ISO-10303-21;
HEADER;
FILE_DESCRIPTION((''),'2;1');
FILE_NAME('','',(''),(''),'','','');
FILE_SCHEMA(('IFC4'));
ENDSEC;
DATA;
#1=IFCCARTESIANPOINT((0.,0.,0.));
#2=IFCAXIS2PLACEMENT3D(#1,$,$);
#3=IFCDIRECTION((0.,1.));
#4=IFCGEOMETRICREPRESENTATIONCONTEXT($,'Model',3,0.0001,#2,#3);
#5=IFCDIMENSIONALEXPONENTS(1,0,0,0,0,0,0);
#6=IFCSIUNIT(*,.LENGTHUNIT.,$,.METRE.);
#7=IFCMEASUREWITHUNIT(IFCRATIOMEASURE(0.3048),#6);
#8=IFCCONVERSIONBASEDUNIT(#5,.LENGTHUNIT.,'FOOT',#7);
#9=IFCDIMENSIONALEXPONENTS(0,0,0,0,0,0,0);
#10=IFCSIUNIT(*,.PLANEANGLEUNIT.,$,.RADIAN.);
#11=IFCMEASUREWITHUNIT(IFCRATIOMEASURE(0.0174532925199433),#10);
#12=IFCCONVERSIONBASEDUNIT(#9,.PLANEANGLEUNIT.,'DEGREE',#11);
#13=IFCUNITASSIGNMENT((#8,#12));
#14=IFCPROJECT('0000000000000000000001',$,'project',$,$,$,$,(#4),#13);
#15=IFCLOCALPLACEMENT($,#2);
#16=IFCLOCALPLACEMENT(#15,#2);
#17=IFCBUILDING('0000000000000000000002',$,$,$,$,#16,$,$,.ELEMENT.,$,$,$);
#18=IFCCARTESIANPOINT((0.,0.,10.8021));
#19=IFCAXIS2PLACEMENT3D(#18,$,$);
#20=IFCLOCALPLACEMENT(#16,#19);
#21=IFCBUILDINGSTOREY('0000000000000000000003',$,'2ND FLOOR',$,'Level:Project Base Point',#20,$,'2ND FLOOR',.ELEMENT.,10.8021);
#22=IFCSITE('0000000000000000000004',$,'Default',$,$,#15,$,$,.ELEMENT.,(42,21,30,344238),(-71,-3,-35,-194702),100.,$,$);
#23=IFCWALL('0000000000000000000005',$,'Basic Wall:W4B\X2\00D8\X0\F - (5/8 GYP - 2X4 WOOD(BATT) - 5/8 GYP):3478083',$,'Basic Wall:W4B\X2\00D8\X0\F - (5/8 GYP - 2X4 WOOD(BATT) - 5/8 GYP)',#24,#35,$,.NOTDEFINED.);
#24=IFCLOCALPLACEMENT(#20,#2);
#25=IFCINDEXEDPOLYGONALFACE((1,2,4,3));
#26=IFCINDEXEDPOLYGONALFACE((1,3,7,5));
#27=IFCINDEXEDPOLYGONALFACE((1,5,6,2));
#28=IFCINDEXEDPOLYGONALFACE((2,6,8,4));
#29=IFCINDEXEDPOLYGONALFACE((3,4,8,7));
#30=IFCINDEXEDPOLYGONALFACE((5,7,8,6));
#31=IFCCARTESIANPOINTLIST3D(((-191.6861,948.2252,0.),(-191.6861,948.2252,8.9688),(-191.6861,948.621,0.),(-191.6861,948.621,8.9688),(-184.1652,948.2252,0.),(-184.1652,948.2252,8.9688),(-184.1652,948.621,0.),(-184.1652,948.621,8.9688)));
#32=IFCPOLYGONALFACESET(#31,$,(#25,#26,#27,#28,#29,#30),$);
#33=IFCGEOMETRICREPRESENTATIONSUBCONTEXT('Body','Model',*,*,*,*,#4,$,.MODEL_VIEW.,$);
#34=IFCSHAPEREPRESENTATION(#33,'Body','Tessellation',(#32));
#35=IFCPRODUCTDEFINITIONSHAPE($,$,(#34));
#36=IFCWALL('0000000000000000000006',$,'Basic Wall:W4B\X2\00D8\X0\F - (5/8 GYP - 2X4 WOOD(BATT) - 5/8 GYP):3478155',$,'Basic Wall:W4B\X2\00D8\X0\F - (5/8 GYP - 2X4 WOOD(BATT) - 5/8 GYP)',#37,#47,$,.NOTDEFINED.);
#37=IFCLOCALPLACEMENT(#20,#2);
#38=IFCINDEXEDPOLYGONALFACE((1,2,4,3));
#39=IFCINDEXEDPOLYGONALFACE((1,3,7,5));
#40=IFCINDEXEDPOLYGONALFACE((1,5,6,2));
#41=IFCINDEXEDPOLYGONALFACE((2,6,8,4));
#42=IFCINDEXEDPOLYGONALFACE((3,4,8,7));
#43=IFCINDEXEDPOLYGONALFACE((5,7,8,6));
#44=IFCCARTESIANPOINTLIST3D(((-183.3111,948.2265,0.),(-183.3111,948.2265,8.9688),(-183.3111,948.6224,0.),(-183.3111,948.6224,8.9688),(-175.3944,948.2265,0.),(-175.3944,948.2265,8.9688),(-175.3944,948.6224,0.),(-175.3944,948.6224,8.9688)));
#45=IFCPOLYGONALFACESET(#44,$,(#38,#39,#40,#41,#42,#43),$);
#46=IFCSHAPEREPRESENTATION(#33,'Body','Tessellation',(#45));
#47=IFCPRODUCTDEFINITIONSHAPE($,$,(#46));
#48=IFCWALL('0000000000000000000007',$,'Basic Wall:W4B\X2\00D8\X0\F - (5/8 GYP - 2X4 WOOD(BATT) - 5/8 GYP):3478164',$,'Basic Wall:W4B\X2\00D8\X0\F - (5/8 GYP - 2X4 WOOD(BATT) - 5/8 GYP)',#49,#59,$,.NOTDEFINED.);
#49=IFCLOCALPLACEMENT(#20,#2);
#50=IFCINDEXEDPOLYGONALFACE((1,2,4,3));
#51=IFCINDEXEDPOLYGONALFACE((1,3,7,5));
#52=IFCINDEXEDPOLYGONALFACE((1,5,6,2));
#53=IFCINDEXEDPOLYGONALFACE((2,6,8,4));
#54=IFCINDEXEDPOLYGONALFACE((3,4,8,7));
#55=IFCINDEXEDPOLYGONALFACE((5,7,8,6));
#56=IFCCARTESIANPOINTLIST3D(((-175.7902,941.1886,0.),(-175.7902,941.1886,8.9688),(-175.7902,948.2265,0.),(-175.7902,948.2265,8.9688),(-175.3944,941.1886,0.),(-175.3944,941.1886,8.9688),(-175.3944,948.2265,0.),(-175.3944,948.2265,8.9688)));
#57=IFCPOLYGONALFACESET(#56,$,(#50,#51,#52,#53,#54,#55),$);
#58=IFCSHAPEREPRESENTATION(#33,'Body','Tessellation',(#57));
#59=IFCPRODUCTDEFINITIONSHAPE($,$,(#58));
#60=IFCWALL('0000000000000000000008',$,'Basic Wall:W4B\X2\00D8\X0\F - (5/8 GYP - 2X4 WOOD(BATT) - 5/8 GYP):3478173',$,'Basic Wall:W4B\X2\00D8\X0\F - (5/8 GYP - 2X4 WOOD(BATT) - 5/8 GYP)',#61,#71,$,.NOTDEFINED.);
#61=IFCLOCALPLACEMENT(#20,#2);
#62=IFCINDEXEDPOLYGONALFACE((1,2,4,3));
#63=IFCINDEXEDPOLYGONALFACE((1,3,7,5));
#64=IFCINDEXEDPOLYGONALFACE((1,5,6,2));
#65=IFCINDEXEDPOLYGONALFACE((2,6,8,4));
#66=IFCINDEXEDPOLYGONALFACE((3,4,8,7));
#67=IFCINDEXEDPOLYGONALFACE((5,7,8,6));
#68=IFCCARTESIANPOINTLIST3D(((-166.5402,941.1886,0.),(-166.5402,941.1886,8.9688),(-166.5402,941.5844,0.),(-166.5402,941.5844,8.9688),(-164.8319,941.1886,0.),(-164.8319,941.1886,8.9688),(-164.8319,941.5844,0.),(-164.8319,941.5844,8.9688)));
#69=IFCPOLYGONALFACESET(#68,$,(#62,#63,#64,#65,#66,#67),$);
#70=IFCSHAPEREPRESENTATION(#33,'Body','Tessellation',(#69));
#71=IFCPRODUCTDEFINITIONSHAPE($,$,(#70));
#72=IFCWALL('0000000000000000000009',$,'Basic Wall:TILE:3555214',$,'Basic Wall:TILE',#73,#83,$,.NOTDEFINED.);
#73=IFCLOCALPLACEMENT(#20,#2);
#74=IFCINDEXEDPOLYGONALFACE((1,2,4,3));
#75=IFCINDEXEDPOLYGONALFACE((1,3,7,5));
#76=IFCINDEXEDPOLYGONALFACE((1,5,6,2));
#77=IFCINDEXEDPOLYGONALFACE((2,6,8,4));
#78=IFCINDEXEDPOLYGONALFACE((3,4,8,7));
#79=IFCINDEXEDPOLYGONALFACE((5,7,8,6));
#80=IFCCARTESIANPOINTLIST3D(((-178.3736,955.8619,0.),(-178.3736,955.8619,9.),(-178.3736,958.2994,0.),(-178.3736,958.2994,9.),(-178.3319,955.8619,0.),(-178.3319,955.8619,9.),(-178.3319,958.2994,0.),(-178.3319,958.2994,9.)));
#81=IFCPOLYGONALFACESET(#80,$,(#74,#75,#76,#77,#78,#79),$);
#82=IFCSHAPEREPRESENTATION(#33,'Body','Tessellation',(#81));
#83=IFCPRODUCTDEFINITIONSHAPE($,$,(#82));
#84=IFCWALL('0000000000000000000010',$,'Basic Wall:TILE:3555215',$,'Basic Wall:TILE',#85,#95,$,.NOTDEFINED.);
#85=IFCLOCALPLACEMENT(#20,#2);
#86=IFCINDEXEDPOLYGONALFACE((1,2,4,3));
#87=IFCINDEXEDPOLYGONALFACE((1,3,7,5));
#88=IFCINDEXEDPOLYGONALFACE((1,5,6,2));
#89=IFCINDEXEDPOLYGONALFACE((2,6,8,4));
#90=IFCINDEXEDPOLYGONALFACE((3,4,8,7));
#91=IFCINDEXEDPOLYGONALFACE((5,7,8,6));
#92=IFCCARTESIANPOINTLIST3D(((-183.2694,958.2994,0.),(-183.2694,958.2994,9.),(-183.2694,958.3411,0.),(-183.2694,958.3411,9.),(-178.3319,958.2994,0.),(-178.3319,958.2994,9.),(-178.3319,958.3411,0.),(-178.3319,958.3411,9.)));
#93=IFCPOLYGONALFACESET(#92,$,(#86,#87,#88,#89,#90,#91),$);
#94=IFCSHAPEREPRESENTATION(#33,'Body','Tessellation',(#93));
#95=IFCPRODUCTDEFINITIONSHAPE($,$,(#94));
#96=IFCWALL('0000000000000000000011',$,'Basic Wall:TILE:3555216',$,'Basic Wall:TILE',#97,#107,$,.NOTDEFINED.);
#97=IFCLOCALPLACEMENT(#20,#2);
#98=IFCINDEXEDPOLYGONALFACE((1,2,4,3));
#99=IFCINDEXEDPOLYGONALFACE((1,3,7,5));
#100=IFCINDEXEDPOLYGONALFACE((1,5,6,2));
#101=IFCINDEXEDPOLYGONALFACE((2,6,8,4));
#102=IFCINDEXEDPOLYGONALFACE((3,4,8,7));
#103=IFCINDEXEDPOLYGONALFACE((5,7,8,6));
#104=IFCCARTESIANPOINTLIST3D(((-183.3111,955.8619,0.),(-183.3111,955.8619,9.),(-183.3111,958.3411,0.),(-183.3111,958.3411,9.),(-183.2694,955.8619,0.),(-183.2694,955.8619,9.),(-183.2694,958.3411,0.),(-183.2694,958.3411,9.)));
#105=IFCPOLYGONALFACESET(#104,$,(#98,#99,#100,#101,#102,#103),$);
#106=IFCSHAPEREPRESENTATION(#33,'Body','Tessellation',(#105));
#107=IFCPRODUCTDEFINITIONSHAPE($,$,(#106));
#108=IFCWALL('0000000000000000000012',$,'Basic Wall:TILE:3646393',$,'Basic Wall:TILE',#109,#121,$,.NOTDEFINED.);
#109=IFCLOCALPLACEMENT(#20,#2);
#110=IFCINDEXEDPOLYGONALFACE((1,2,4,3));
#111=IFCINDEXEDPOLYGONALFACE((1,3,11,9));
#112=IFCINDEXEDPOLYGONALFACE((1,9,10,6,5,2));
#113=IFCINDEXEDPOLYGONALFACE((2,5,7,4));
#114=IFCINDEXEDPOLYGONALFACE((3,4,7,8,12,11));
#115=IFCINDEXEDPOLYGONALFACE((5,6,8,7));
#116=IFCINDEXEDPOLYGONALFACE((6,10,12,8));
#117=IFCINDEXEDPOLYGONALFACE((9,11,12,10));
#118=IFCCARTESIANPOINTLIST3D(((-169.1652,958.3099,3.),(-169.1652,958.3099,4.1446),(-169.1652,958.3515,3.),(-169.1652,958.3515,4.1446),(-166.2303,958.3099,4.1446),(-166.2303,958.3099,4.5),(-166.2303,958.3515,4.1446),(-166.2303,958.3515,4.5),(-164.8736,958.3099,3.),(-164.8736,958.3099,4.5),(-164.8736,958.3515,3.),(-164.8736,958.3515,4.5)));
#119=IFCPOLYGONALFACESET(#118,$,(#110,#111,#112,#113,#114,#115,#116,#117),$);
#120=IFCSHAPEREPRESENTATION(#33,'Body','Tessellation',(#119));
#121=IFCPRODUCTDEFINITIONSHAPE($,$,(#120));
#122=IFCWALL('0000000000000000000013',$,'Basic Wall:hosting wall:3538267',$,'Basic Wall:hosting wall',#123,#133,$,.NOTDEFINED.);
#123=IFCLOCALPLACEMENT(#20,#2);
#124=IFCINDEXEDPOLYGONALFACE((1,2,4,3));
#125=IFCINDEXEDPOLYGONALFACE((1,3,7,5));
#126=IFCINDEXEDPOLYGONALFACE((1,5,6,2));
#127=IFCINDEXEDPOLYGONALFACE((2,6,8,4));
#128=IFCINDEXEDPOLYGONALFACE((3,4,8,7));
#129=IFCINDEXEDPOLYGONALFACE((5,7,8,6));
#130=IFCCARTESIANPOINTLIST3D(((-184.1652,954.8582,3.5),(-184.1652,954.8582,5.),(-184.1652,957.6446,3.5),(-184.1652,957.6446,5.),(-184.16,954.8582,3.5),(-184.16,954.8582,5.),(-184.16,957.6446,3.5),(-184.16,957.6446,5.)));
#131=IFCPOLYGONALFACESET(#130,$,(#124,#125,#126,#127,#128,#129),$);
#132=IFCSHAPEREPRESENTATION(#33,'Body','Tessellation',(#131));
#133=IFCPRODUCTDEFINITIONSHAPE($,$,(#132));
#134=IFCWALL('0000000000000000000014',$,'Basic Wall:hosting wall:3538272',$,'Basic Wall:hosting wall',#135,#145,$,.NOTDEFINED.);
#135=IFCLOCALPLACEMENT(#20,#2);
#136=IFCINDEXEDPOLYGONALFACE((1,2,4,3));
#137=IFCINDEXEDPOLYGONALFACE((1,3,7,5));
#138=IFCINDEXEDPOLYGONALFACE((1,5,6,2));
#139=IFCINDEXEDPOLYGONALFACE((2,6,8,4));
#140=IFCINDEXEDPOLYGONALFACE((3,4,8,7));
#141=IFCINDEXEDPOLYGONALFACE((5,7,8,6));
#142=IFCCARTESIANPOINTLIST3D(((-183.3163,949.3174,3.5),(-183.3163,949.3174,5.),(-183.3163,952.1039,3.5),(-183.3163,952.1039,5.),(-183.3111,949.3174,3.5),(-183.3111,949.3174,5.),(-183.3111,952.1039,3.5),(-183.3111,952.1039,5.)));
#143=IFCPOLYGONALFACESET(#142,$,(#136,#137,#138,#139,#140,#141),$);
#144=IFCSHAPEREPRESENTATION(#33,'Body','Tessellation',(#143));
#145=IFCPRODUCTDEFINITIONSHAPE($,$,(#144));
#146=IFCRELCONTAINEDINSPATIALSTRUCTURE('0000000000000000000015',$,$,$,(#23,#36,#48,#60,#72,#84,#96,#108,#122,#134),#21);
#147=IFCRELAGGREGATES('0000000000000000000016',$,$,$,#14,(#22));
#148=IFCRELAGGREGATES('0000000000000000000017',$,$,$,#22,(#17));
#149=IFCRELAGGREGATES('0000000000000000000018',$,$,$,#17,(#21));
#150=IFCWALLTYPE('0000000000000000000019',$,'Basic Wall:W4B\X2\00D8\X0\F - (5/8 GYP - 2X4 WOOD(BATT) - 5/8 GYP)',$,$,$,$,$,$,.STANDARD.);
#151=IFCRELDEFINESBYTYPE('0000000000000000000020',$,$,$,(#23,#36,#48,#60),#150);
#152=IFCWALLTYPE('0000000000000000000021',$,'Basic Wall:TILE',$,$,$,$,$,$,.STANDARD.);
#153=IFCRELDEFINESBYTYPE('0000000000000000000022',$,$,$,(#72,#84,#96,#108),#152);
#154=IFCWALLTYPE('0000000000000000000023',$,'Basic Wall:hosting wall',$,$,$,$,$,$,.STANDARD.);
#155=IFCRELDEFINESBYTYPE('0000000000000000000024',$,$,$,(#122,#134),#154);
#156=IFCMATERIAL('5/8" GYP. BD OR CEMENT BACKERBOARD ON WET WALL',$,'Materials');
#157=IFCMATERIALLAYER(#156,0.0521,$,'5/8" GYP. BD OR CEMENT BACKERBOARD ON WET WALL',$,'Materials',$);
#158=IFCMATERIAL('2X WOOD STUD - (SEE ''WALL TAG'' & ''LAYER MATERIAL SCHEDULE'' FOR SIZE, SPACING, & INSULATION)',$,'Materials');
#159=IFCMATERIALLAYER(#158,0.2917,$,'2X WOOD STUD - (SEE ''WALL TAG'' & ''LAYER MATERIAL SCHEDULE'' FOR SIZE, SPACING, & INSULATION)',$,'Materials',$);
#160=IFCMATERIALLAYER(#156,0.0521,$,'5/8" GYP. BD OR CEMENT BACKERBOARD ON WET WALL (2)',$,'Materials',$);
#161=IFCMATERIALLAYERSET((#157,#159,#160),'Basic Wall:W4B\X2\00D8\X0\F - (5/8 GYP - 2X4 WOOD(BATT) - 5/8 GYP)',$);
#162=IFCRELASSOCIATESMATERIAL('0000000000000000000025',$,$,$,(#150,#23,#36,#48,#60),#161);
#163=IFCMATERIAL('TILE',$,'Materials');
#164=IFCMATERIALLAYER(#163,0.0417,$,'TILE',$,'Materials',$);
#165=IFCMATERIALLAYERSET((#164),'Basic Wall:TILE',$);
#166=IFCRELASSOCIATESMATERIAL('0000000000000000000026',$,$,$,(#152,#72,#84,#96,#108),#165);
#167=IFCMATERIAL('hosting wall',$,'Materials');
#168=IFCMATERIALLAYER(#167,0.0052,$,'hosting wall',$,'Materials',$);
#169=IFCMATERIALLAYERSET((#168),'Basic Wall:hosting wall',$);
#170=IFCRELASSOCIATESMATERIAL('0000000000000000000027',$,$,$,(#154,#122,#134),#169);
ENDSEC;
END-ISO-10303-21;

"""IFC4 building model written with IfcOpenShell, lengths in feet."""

from ifc_helpers import new_model, entity, si_unit, converted_unit, direction, frame, frame_2d, origin, place, context, subcontext, project, spatial, rectangle, extrude, material, layer, layer_set, layer_usage, type_object, element, save


model = new_model("IFC4")

# Units and contexts
model_context = context("Model", 3, precision=0.0001, world=origin(), true_north=direction((0.0, 1.0)))
body_context = subcontext(model_context, "Body", "Model", "MODEL_VIEW")
ifc_project = project(units=[converted_unit("LENGTHUNIT", "FOOT", entity("IfcRatioMeasure", 0.3048), si_unit("LENGTHUNIT", "METRE"), dimensions=[1, 0, 0, 0, 0, 0, 0]), converted_unit("PLANEANGLEUNIT", "DEGREE", entity("IfcRatioMeasure", 0.0174532925199433), si_unit("PLANEANGLEUNIT", "RADIAN"), dimensions=[0, 0, 0, 0, 0, 0, 0])], contexts=[model_context])

# Site, building, storey
site_placement = place(None, origin())
site = spatial("IfcSite", under=ifc_project, at=site_placement, Name="Default", CompositionType="ELEMENT", RefLatitude=(42, 21, 30, 344238), RefLongitude=(-71, -3, -35, -194702), RefElevation=100.0)
building_placement = place(site_placement, origin())
building = spatial("IfcBuilding", under=site, at=building_placement, CompositionType="ELEMENT")
storey_placement = place(building_placement, frame((0.0, 0.0, 10.8021)))
storey = spatial("IfcBuildingStorey", under=building, at=storey_placement, Name="2ND FLOOR", ObjectType="Level:Project Base Point", LongName="2ND FLOOR", CompositionType="ELEMENT", Elevation=10.8021)

# Walls
ifc_material_1 = material(Name="5/8\" GYP. BD OR CEMENT BACKERBOARD ON WET WALL", Category="Materials")
ifc_layer_1 = layer(ifc_material_1, 0.0521, Name="5/8\" GYP. BD OR CEMENT BACKERBOARD ON WET WALL", Category="Materials")
ifc_material_2 = material(Name="2X WOOD STUD - (SEE 'WALL TAG' & 'LAYER MATERIAL SCHEDULE' FOR SIZE, SPACING, & INSULATION)", Category="Materials")
ifc_layer_2 = layer(ifc_material_2, 0.2917, Name="2X WOOD STUD - (SEE 'WALL TAG' & 'LAYER MATERIAL SCHEDULE' FOR SIZE, SPACING, & INSULATION)", Category="Materials")
ifc_layer_3 = layer(ifc_material_1, 0.0521, Name="5/8\" GYP. BD OR CEMENT BACKERBOARD ON WET WALL (2)", Category="Materials")
ifc_layer_set_1 = layer_set([ifc_layer_1, ifc_layer_2, ifc_layer_3], Name="Basic Wall:W4BØF - (5/8 GYP - 2X4 WOOD(BATT) - 5/8 GYP)")
ifc_layer_usage_1 = layer_usage(ifc_layer_set_1, "AXIS2", "NEGATIVE", 0.1979)
wall_type_1 = type_object("IfcWallType", Name="Basic Wall:W4BØF - (5/8 GYP - 2X4 WOOD(BATT) - 5/8 GYP)", PredefinedType="STANDARD", material=ifc_layer_set_1)
wall_1_placement = place(storey_placement, frame((-184.1652, 948.4231, 0.0), z_axis=(0.0, 0.0, 1.0), x_axis=(-1.0, 0.0, 0.0)))
element("IfcWall", 1, at=wall_1_placement, inside=storey, type_object=wall_type_1, material=ifc_layer_usage_1, Name="Basic Wall:W4BØF - (5/8 GYP - 2X4 WOOD(BATT) - 5/8 GYP):3478083", ObjectType="Basic Wall:W4BØF - (5/8 GYP - 2X4 WOOD(BATT) - 5/8 GYP)", PredefinedType="NOTDEFINED", context=body_context, shape_type="SweptSolid", body=[
    extrude(rectangle(XDim=7.5208, YDim=0.3958, at=frame_2d((3.7604, 0.0), x_axis=(-1.0, 0.0))), origin(), (0.0, 0.0, 1.0), 8.9688),
])
ifc_layer_usage_2 = layer_usage(ifc_layer_set_1, "AXIS2", "POSITIVE", -0.1979)
wall_2_placement = place(storey_placement, frame((-183.3111, 948.4244, 0.0)))
element("IfcWall", 2, at=wall_2_placement, inside=storey, type_object=wall_type_1, material=ifc_layer_usage_2, Name="Basic Wall:W4BØF - (5/8 GYP - 2X4 WOOD(BATT) - 5/8 GYP):3478155", ObjectType="Basic Wall:W4BØF - (5/8 GYP - 2X4 WOOD(BATT) - 5/8 GYP)", PredefinedType="NOTDEFINED", context=body_context, shape_type="SweptSolid", body=[
    extrude(rectangle(XDim=7.9167, YDim=0.3958, at=frame_2d((3.9583, 0.0), x_axis=(-1.0, 0.0))), origin(), (0.0, 0.0, 1.0), 8.9688),
])

# Wall
ifc_layer_usage_3 = layer_usage(ifc_layer_set_1, "AXIS2", "POSITIVE", -0.1979)
wall_3_placement = place(storey_placement, frame((-175.5923, 941.1886, 0.0), z_axis=(0.0, 0.0, 1.0), x_axis=(0.0, 1.0, 0.0)))
element("IfcWall", 3, at=wall_3_placement, inside=storey, type_object=wall_type_1, material=ifc_layer_usage_3, Name="Basic Wall:W4BØF - (5/8 GYP - 2X4 WOOD(BATT) - 5/8 GYP):3478164", ObjectType="Basic Wall:W4BØF - (5/8 GYP - 2X4 WOOD(BATT) - 5/8 GYP)", PredefinedType="NOTDEFINED", context=body_context, shape_type="SweptSolid", body=[
    extrude(rectangle(XDim=7.038, YDim=0.3958, at=frame_2d((3.519, 0.0), x_axis=(-1.0, 0.0))), origin(), (0.0, 0.0, 1.0), 8.9688),
])

# Walls
ifc_layer_usage_4 = layer_usage(ifc_layer_set_1, "AXIS2", "POSITIVE", -0.1979)
wall_4_placement = place(storey_placement, frame((-166.5402, 941.3865, 0.0)))
element("IfcWall", 4, at=wall_4_placement, inside=storey, type_object=wall_type_1, material=ifc_layer_usage_4, Name="Basic Wall:W4BØF - (5/8 GYP - 2X4 WOOD(BATT) - 5/8 GYP):3478173", ObjectType="Basic Wall:W4BØF - (5/8 GYP - 2X4 WOOD(BATT) - 5/8 GYP)", PredefinedType="NOTDEFINED", context=body_context, shape_type="SweptSolid", body=[
    extrude(rectangle(XDim=1.7083, YDim=0.3958, at=frame_2d((0.8542, 0.0), x_axis=(-1.0, 0.0))), origin(), (0.0, 0.0, 1.0), 8.9688),
])
ifc_material_3 = material(Name="TILE", Category="Materials")
ifc_layer_4 = layer(ifc_material_3, 0.0417, Name="TILE", Category="Materials")
ifc_layer_set_2 = layer_set([ifc_layer_4], Name="Basic Wall:TILE")
ifc_layer_usage_5 = layer_usage(ifc_layer_set_2, "AXIS2", "POSITIVE", -0.0208)
wall_type_2 = type_object("IfcWallType", Name="Basic Wall:TILE", PredefinedType="STANDARD", material=ifc_layer_set_2)
wall_5_placement = place(storey_placement, frame((-178.3527, 955.8619, 0.0), z_axis=(0.0, 0.0, 1.0), x_axis=(0.0, 1.0, 0.0)))
element("IfcWall", 5, at=wall_5_placement, inside=storey, type_object=wall_type_2, material=ifc_layer_usage_5, Name="Basic Wall:TILE:3555214", ObjectType="Basic Wall:TILE", PredefinedType="NOTDEFINED", context=body_context, shape_type="SweptSolid", body=[
    extrude(rectangle(XDim=2.4375, YDim=0.0417, at=frame_2d((1.2187, 0.0), x_axis=(-1.0, 0.0))), origin(), (0.0, 0.0, 1.0), 9.0),
])
ifc_layer_usage_6 = layer_usage(ifc_layer_set_2, "AXIS2", "POSITIVE", -0.0208)
wall_6_placement = place(storey_placement, frame((-178.3319, 958.3203, 0.0), z_axis=(0.0, 0.0, 1.0), x_axis=(-1.0, 0.0, 0.0)))
element("IfcWall", 6, at=wall_6_placement, inside=storey, type_object=wall_type_2, material=ifc_layer_usage_6, Name="Basic Wall:TILE:3555215", ObjectType="Basic Wall:TILE", PredefinedType="NOTDEFINED", context=body_context, shape_type="SweptSolid", body=[
    extrude(rectangle(XDim=4.9375, YDim=0.0417, at=frame_2d((2.4688, 0.0), x_axis=(-1.0, 0.0))), origin(), (0.0, 0.0, 1.0), 9.0),
])
ifc_layer_usage_7 = layer_usage(ifc_layer_set_2, "AXIS2", "POSITIVE", -0.0208)
wall_7_placement = place(storey_placement, frame((-183.2902, 958.3411, 0.0), z_axis=(0.0, 0.0, 1.0), x_axis=(0.0, -1.0, 0.0)))
element("IfcWall", 7, at=wall_7_placement, inside=storey, type_object=wall_type_2, material=ifc_layer_usage_7, Name="Basic Wall:TILE:3555216", ObjectType="Basic Wall:TILE", PredefinedType="NOTDEFINED", context=body_context, shape_type="SweptSolid", body=[
    extrude(rectangle(XDim=2.4792, YDim=0.0417, at=frame_2d((1.2396, 0.0), x_axis=(-1.0, 0.0))), origin(), (0.0, 0.0, 1.0), 9.0),
])

# Wall, opening
ifc_layer_usage_8 = layer_usage(ifc_layer_set_2, "AXIS2", "POSITIVE", -0.0208)
wall_8_placement = place(storey_placement, frame((-164.8736, 958.3307, 3.0), z_axis=(0.0, 0.0, 1.0), x_axis=(-1.0, 0.0, 0.0)))
wall_8 = element("IfcWall", 8, at=wall_8_placement, inside=storey, type_object=wall_type_2, material=ifc_layer_usage_8, Name="Basic Wall:TILE:3646393", ObjectType="Basic Wall:TILE", PredefinedType="NOTDEFINED", context=body_context, shape_type="SweptSolid", body=[
    extrude(rectangle(XDim=4.2917, YDim=0.0417, at=frame_2d((2.1458, 0.0), x_axis=(-1.0, 0.0))), origin(), (0.0, 0.0, 1.0), 1.5),
])
opening_1_placement = place(wall_8_placement, origin())
element("IfcOpeningElement", 9, at=opening_1_placement, cuts=wall_8, PredefinedType="OPENING", context=body_context, shape_type="SweptSolid", body=[
    extrude(rectangle(XDim=0.3554, YDim=2.9349, at=frame_2d((0.0, 0.0), x_axis=(1.0, 0.0))), frame((2.8242, 0.0208, 1.3223), z_axis=(0.0, -1.0, 0.0), x_axis=(0.0, 0.0, 1.0)), (0.0, 0.0, 1.0), 0.0417),
])

# Walls
ifc_material_4 = material(Name="hosting wall", Category="Materials")
ifc_layer_5 = layer(ifc_material_4, 0.0052, Name="hosting wall", Category="Materials")
ifc_layer_set_3 = layer_set([ifc_layer_5], Name="Basic Wall:hosting wall")
ifc_layer_usage_9 = layer_usage(ifc_layer_set_3, "AXIS2", "NEGATIVE", 0.0026)
wall_type_3 = type_object("IfcWallType", Name="Basic Wall:hosting wall", PredefinedType="STANDARD", material=ifc_layer_set_3)
wall_9_placement = place(storey_placement, frame((-184.1626, 957.6446, 3.5), z_axis=(0.0, 0.0, 1.0), x_axis=(0.0, -1.0, 0.0)))
element("IfcWall", 10, at=wall_9_placement, inside=storey, type_object=wall_type_3, material=ifc_layer_usage_9, Name="Basic Wall:hosting wall:3538267", ObjectType="Basic Wall:hosting wall", PredefinedType="NOTDEFINED", context=body_context, shape_type="SweptSolid", body=[
    extrude(rectangle(XDim=2.7865, YDim=0.0052, at=frame_2d((1.3932, 0.0), x_axis=(-1.0, 0.0))), origin(), (0.0, 0.0, 1.0), 1.5),
])
ifc_layer_usage_10 = layer_usage(ifc_layer_set_3, "AXIS2", "NEGATIVE", 0.0026)
wall_10_placement = place(storey_placement, frame((-183.3137, 949.3174, 3.5), z_axis=(0.0, 0.0, 1.0), x_axis=(0.0, 1.0, 0.0)))
element("IfcWall", 11, at=wall_10_placement, inside=storey, type_object=wall_type_3, material=ifc_layer_usage_10, Name="Basic Wall:hosting wall:3538272", ObjectType="Basic Wall:hosting wall", PredefinedType="NOTDEFINED", context=body_context, shape_type="SweptSolid", body=[
    extrude(rectangle(XDim=2.7865, YDim=0.0052, at=frame_2d((1.3932, 0.0), x_axis=(-1.0, 0.0))), origin(), (0.0, 0.0, 1.0), 1.5),
])

save(model, "model.ifc")
